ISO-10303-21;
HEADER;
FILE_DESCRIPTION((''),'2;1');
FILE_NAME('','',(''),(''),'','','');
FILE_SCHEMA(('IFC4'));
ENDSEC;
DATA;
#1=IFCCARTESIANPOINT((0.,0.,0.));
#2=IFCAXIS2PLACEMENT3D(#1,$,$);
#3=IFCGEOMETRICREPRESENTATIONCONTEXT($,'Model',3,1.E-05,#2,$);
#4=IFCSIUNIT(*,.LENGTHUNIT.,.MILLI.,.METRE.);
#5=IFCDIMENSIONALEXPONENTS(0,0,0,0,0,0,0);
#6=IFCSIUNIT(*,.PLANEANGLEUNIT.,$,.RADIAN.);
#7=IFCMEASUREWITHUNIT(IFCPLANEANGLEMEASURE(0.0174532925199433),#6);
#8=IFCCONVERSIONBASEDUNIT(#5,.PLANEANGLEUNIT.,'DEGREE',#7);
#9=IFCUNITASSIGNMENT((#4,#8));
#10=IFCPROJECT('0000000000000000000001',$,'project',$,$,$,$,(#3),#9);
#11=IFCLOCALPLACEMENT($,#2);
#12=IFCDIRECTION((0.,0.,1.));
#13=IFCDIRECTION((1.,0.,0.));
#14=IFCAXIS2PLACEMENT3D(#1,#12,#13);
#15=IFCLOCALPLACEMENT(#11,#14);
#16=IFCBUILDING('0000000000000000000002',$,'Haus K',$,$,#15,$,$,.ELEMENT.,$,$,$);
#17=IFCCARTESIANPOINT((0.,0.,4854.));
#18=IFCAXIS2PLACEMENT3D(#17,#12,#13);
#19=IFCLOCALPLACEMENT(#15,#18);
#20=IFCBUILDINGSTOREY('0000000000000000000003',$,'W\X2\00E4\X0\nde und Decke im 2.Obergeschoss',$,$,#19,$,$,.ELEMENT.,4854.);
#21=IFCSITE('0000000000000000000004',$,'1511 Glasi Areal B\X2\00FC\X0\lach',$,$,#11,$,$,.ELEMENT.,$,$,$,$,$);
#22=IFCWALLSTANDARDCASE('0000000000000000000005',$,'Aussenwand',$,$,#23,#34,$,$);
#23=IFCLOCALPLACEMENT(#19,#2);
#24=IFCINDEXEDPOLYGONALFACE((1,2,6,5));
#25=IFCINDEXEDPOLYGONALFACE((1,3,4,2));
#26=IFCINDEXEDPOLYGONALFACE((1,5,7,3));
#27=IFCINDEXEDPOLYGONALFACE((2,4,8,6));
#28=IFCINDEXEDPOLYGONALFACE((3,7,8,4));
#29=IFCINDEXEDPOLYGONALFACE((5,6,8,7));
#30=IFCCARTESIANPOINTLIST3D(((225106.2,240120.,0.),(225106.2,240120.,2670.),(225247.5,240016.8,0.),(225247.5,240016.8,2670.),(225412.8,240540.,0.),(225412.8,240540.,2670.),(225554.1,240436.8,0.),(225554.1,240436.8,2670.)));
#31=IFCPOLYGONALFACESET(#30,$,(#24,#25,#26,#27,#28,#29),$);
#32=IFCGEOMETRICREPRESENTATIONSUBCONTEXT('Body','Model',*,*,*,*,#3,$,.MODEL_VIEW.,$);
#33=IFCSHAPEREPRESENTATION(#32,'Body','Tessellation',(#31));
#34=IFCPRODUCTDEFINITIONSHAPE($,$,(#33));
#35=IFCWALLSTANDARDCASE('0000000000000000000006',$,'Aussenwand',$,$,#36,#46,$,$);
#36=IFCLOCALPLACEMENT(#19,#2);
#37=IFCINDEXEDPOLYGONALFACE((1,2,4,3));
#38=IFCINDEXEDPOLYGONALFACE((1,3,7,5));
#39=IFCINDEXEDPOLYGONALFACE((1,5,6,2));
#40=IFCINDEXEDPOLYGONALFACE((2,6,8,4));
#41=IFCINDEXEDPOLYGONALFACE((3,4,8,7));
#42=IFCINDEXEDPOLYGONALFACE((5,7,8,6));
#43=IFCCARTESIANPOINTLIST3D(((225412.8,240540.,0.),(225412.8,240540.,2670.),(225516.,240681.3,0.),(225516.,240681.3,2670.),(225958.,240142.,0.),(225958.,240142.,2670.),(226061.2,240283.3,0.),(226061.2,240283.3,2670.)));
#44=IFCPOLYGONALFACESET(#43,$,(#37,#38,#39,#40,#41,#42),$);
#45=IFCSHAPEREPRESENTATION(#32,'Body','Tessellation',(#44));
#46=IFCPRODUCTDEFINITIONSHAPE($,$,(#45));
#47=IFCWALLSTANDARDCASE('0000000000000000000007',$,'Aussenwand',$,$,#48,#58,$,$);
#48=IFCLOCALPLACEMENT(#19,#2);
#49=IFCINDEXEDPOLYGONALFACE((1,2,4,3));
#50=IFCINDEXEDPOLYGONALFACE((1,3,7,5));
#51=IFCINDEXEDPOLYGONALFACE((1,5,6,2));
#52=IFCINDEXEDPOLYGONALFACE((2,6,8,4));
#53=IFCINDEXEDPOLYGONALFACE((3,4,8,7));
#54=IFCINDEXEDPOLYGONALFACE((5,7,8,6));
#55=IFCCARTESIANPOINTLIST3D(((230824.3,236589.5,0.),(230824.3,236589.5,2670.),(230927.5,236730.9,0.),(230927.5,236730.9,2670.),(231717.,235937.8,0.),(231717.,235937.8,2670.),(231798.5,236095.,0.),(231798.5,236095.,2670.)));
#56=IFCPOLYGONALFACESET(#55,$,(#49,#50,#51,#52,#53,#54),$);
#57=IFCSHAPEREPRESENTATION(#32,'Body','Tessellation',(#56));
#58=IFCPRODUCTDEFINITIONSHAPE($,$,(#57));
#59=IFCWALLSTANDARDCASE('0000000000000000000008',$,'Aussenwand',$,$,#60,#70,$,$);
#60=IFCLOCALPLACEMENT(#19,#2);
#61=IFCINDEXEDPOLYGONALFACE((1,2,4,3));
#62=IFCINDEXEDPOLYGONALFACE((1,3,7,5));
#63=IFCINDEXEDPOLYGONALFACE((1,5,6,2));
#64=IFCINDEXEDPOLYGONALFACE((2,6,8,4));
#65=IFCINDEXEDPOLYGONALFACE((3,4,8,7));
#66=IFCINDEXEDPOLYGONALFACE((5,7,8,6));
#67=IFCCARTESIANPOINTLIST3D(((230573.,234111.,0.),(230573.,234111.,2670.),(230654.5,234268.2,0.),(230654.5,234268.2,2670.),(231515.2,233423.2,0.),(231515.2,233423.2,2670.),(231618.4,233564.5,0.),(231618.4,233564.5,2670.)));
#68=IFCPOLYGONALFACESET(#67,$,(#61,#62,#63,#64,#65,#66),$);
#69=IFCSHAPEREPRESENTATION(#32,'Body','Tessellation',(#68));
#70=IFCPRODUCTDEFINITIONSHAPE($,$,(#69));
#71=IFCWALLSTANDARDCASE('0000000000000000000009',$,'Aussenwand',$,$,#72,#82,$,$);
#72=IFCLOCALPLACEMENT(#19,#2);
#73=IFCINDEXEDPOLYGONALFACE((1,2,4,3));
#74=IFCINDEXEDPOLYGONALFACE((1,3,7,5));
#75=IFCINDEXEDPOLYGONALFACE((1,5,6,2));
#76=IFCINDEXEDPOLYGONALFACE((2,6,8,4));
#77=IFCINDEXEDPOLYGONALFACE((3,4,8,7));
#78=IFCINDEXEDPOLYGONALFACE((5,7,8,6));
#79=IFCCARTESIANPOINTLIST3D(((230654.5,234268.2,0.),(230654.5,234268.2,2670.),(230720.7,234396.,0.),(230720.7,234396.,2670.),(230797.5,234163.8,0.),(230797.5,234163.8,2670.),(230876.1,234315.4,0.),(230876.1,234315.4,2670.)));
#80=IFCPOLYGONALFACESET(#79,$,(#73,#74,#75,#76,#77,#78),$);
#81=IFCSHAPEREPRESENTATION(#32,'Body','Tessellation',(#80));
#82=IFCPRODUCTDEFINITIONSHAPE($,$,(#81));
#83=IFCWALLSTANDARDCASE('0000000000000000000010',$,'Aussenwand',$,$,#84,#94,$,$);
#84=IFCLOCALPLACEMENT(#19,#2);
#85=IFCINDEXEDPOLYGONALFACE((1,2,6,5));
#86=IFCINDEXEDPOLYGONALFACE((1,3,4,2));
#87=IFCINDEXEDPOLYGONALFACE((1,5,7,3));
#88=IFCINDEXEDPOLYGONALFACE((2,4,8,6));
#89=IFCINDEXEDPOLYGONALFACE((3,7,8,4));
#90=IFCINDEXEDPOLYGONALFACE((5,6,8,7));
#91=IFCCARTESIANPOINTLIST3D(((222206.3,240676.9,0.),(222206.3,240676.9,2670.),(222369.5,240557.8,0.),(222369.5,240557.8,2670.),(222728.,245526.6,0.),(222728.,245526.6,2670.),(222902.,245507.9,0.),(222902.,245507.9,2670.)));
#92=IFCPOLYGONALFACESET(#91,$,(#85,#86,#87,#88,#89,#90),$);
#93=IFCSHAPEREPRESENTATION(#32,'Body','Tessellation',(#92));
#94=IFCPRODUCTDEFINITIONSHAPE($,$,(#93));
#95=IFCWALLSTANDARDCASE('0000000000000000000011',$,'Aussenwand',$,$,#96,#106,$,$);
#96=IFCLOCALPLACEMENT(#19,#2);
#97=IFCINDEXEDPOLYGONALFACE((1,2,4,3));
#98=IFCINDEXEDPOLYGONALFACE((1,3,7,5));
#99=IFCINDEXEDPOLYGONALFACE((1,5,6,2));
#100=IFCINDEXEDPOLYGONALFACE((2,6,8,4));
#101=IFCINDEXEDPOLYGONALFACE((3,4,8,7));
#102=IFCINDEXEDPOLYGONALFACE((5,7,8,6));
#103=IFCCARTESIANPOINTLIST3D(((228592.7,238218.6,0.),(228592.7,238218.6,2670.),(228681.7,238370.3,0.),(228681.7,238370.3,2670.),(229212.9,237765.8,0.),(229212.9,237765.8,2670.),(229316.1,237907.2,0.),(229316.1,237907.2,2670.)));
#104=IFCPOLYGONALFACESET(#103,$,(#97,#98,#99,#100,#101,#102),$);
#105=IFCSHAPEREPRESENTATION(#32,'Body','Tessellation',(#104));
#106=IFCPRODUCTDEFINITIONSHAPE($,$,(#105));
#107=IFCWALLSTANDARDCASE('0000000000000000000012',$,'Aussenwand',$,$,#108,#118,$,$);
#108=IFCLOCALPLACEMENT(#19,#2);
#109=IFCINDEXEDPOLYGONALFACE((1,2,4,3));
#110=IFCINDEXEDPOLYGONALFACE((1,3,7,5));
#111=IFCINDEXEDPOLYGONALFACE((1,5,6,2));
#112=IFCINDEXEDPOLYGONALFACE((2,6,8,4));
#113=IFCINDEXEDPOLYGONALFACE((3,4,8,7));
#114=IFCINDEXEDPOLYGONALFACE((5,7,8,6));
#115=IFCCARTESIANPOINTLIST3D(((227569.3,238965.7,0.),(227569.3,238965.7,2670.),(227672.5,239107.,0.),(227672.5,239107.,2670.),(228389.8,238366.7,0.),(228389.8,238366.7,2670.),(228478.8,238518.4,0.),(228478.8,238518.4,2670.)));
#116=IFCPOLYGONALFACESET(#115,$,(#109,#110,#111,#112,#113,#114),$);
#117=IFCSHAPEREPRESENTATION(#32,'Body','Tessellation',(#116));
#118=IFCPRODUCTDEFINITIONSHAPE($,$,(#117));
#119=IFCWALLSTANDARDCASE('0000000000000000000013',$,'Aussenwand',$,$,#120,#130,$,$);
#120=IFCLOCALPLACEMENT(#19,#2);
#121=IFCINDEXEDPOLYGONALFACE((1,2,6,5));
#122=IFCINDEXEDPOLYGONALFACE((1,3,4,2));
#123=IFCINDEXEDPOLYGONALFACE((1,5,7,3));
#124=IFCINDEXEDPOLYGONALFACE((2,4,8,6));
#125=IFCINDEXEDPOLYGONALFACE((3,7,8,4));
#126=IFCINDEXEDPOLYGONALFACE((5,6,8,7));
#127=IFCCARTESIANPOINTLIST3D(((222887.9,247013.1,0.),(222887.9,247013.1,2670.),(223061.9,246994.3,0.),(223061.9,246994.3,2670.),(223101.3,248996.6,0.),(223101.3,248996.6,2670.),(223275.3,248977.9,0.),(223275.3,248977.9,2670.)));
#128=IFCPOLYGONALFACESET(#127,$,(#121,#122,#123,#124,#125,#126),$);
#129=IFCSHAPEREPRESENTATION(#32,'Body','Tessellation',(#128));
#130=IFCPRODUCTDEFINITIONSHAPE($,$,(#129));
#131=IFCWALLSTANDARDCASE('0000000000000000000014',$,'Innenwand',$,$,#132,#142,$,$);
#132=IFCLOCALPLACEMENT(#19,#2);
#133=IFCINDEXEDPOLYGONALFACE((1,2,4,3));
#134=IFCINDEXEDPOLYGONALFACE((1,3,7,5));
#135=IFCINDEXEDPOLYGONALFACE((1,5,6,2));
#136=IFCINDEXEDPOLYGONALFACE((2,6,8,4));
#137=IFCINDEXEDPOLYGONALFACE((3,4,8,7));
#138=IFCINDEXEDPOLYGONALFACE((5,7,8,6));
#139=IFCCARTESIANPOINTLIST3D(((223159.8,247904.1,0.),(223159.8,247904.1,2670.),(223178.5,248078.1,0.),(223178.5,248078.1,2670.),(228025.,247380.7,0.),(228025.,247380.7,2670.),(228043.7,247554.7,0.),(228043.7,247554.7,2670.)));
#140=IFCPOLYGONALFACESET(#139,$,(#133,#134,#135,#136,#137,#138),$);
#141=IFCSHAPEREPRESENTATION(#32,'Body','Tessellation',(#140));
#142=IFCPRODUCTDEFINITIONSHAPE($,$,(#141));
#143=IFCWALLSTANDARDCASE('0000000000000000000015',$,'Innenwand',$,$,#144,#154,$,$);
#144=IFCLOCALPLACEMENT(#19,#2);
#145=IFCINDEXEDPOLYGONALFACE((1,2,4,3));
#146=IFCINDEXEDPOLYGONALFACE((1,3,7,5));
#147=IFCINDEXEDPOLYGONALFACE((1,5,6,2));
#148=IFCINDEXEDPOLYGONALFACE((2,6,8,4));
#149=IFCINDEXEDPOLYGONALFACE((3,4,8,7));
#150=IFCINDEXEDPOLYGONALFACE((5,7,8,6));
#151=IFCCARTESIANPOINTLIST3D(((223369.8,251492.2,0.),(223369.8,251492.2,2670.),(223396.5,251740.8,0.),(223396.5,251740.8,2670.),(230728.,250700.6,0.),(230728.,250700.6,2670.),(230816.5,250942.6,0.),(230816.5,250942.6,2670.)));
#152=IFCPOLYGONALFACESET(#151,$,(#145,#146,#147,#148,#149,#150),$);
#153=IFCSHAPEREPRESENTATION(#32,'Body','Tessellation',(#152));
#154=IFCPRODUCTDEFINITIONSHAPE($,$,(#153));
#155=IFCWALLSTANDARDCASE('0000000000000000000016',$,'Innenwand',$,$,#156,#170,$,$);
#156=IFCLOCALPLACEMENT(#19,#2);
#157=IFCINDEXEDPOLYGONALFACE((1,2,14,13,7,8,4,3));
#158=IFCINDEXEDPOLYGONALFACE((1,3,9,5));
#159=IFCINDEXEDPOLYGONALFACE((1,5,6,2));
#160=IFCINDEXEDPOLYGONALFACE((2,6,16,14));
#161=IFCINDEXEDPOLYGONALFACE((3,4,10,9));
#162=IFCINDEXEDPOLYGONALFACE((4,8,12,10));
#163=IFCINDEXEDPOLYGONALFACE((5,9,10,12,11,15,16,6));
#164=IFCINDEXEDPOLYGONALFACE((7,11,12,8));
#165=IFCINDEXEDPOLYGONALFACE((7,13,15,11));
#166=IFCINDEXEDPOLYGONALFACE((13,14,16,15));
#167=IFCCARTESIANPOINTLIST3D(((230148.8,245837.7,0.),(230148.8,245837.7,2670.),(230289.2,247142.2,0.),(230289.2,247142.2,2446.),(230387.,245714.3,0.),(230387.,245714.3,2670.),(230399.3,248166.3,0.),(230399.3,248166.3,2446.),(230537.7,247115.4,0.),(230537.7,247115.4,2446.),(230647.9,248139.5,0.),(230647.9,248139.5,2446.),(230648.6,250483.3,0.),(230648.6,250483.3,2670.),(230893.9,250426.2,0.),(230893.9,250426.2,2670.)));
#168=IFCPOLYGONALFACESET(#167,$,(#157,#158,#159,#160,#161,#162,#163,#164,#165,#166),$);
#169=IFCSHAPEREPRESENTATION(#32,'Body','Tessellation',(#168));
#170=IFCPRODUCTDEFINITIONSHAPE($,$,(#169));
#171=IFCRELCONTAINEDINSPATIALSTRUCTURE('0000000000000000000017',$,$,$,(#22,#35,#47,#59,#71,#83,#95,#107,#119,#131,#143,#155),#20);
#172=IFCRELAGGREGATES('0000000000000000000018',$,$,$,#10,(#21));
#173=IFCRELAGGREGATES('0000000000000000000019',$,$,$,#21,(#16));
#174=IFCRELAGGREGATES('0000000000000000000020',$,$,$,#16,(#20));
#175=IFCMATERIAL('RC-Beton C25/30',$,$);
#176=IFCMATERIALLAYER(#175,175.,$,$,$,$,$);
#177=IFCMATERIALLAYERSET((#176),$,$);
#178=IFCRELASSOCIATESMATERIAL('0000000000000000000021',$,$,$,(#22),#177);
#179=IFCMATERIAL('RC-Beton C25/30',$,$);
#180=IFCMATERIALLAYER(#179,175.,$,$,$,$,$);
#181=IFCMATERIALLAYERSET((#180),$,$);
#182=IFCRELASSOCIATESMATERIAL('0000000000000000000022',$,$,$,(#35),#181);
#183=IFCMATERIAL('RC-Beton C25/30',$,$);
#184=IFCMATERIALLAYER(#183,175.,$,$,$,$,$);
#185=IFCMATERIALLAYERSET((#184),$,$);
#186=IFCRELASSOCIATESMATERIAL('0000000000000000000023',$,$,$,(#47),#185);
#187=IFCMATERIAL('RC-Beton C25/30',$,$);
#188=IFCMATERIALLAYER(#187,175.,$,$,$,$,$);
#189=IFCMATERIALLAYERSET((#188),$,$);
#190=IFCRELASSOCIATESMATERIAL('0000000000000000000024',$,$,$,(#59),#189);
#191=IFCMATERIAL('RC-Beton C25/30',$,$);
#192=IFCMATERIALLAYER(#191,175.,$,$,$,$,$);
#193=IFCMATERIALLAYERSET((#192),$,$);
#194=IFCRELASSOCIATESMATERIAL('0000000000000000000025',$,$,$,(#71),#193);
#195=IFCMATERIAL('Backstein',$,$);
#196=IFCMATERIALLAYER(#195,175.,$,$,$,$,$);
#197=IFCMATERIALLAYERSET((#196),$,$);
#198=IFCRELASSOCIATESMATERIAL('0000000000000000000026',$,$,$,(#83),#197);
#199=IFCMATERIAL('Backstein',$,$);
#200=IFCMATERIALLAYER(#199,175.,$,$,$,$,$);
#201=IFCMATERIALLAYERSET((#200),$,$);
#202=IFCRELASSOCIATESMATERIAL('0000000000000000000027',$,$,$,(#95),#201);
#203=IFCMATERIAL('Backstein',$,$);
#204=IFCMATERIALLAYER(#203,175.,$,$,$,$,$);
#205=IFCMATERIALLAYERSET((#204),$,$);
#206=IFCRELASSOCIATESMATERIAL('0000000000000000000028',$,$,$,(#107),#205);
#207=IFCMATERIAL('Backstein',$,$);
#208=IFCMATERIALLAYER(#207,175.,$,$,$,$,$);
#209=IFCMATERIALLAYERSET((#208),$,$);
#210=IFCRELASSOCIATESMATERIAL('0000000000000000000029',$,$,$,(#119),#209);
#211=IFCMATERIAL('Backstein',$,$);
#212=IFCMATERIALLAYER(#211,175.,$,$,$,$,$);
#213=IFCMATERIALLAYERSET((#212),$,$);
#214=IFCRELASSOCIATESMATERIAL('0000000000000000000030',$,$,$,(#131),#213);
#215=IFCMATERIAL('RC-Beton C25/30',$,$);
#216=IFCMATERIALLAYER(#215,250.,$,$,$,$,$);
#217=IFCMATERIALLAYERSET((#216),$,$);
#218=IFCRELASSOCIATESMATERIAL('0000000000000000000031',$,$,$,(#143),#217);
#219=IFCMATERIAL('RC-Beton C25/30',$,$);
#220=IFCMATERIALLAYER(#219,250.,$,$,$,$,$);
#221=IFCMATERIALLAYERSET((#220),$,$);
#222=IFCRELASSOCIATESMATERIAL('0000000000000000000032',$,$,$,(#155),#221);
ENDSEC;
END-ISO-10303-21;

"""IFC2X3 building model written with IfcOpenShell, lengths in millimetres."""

from ifc_helpers import new_model, entity, si_unit, converted_unit, frame, frame_2d, origin, origin_with_axes, place, context, subcontext, project, spatial, polyline, rectangle, outline, extrude, material, layer, layer_set, layer_usage, element, save


model = new_model("IFC2X3")

# Units and contexts
model_context = context("Model", 3, precision=1e-05, world=origin())
body_context = subcontext(model_context, "Body", "Model", "MODEL_VIEW")
ifc_project = project(units=[si_unit("LENGTHUNIT", "METRE", prefix="MILLI"), converted_unit("PLANEANGLEUNIT", "DEGREE", entity("IfcPlaneAngleMeasure", 0.0174532925199433), si_unit("PLANEANGLEUNIT", "RADIAN"), dimensions=[0, 0, 0, 0, 0, 0, 0])], contexts=[model_context])

# Site, building, storey
site_placement = place(None, origin())
site = spatial("IfcSite", under=ifc_project, at=site_placement, Name="1511 Glasi Areal Bülach", CompositionType="ELEMENT")
building_placement = place(site_placement, origin_with_axes())
building = spatial("IfcBuilding", under=site, at=building_placement, Name="Haus K", CompositionType="ELEMENT")
storey_placement = place(building_placement, frame((0.0, 0.0, 4854.0), z_axis=(0.0, 0.0, 1.0), x_axis=(1.0, 0.0, 0.0)))
storey = spatial("IfcBuildingStorey", under=building, at=storey_placement, Name="Wände und Decke im 2.Obergeschoss", CompositionType="ELEMENT", Elevation=4854.0)

# Walls
ifc_material_1 = material(Name="RC-Beton C25/30")
ifc_layer_1 = layer(ifc_material_1, 175.0)
ifc_layer_set_1 = layer_set([ifc_layer_1])
ifc_layer_usage_1 = layer_usage(ifc_layer_set_1, "AXIS2", "POSITIVE", 0.0)
wall_1_placement = place(storey_placement, frame((225247.5, 240016.8, 0.0), z_axis=(0.0, 0.0, 1.0), x_axis=(0.589619, 0.807681, 0.0)))
element("IfcWallStandardCase", 1, at=wall_1_placement, inside=storey, material=ifc_layer_usage_1, Name="Aussenwand", context=body_context, shape_type="SweptSolid", body=[
    extrude(rectangle(XDim=520.0, YDim=175.0, at=frame_2d((260.0, 87.5), x_axis=(1.0, 0.0))), origin_with_axes(), (0.0, 0.0, 1.0), 2670.0),
])
ifc_material_2 = material(Name="RC-Beton C25/30")
ifc_layer_2 = layer(ifc_material_2, 175.0)
ifc_layer_set_2 = layer_set([ifc_layer_2])
ifc_layer_usage_2 = layer_usage(ifc_layer_set_2, "AXIS2", "POSITIVE", 0.0)
wall_2_placement = place(storey_placement, frame((225412.8, 240540.0, 0.0), z_axis=(0.0, 0.0, 1.0), x_axis=(0.807681, -0.589619, 0.0)))
element("IfcWallStandardCase", 2, at=wall_2_placement, inside=storey, material=ifc_layer_usage_2, Name="Aussenwand", context=body_context, shape_type="SweptSolid", body=[
    extrude(rectangle(XDim=675.0, YDim=175.0, at=frame_2d((337.5, 87.5), x_axis=(1.0, 0.0))), origin_with_axes(), (0.0, 0.0, 1.0), 2670.0),
])
ifc_material_3 = material(Name="RC-Beton C25/30")
ifc_layer_3 = layer(ifc_material_3, 175.0)
ifc_layer_set_3 = layer_set([ifc_layer_3])
ifc_layer_usage_3 = layer_usage(ifc_layer_set_3, "AXIS2", "POSITIVE", 0.0)
wall_3_placement = place(storey_placement, frame((230824.3, 236589.5, 0.0), z_axis=(0.0, 0.0, 1.0), x_axis=(0.807681, -0.589619, 0.0)))
element("IfcWallStandardCase", 3, at=wall_3_placement, inside=storey, material=ifc_layer_usage_3, Name="Aussenwand", context=body_context, shape_type="SweptSolid", body=[
    extrude(outline(polyline([(0.0, 0.0), (1105.3, 0.0), (1078.5, 175.0), (0.0, 175.0), (0.0, 0.0)])), origin_with_axes(), (0.0, 0.0, 1.0), 2670.0),
])
ifc_material_4 = material(Name="RC-Beton C25/30")
ifc_layer_4 = layer(ifc_material_4, 175.0)
ifc_layer_set_4 = layer_set([ifc_layer_4])
ifc_layer_usage_4 = layer_usage(ifc_layer_set_4, "AXIS2", "POSITIVE", 0.0)
wall_4_placement = place(storey_placement, frame((230573.0, 234111.0, 0.0), z_axis=(0.0, 0.0, 1.0), x_axis=(0.807681, -0.589619, 0.0)))
element("IfcWallStandardCase", 4, at=wall_4_placement, inside=storey, material=ifc_layer_usage_4, Name="Aussenwand", context=body_context, shape_type="SweptSolid", body=[
    extrude(outline(polyline([(0.0, 0.0), (1166.6, 0.0), (1166.6, 175.0), (-26.9, 175.0), (0.0, 0.0)])), origin_with_axes(), (0.0, 0.0, 1.0), 2670.0),
])
ifc_material_5 = material(Name="RC-Beton C25/30")
ifc_layer_5 = layer(ifc_material_5, 175.0)
ifc_layer_set_5 = layer_set([ifc_layer_5])
ifc_layer_usage_5 = layer_usage(ifc_layer_set_5, "AXIS2", "POSITIVE", 0.0)
wall_5_placement = place(storey_placement, frame((230720.7, 234396.0, 0.0), z_axis=(0.0, 0.0, 1.0), x_axis=(-0.4602, -0.887815, 0.0)))
element("IfcWallStandardCase", 5, at=wall_5_placement, inside=storey, material=ifc_layer_usage_5, Name="Aussenwand", context=body_context, shape_type="SweptSolid", body=[
    extrude(outline(polyline([(0.0, 0.0), (143.9, 0.0), (170.8, 175.0), (0.0, 175.0), (0.0, 0.0)])), origin_with_axes(), (0.0, 0.0, 1.0), 2670.0),
])
ifc_material_6 = material(Name="Backstein")
ifc_layer_6 = layer(ifc_material_6, 175.0)
ifc_layer_set_6 = layer_set([ifc_layer_6])
ifc_layer_usage_6 = layer_usage(ifc_layer_set_6, "AXIS2", "POSITIVE", 0.0)
wall_6_placement = place(storey_placement, frame((222728.0, 245526.6, 0.0), z_axis=(0.0, 0.0, 1.0), x_axis=(-0.106958, -0.994264, 0.0)))
element("IfcWallStandardCase", 6, at=wall_6_placement, inside=storey, material=ifc_layer_usage_6, Name="Aussenwand", context=body_context, shape_type="SweptSolid", body=[
    extrude(outline(polyline([(0.0, 0.0), (4877.7, 0.0), (4978.7, 175.0), (0.0, 175.0), (0.0, 0.0)])), origin_with_axes(), (0.0, 0.0, 1.0), 2670.0),
])
ifc_material_7 = material(Name="Backstein")
ifc_layer_7 = layer(ifc_material_7, 175.0)
ifc_layer_set_7 = layer_set([ifc_layer_7])
ifc_layer_usage_7 = layer_usage(ifc_layer_set_7, "AXIS2", "POSITIVE", 0.0)
wall_7_placement = place(storey_placement, frame((228592.7, 238218.6, 0.0), z_axis=(0.0, 0.0, 1.0), x_axis=(0.807681, -0.589619, 0.0)))
element("IfcWallStandardCase", 7, at=wall_7_placement, inside=storey, material=ifc_layer_usage_7, Name="Aussenwand", context=body_context, shape_type="SweptSolid", body=[
    extrude(outline(polyline([(0.0, 0.0), (767.9, 0.0), (767.9, 175.0), (-17.6, 175.0), (0.0, 0.0)])), origin_with_axes(), (0.0, 0.0, 1.0), 2670.0),
])
ifc_material_8 = material(Name="Backstein")
ifc_layer_8 = layer(ifc_material_8, 175.0)
ifc_layer_set_8 = layer_set([ifc_layer_8])
ifc_layer_usage_8 = layer_usage(ifc_layer_set_8, "AXIS2", "POSITIVE", 0.0)
wall_8_placement = place(storey_placement, frame((227569.3, 238965.7, 0.0), z_axis=(0.0, 0.0, 1.0), x_axis=(0.807681, -0.589619, 0.0)))
element("IfcWallStandardCase", 8, at=wall_8_placement, inside=storey, material=ifc_layer_usage_8, Name="Aussenwand", context=body_context, shape_type="SweptSolid", body=[
    extrude(outline(polyline([(0.0, 0.0), (1015.8, 0.0), (998.3, 175.0), (0.0, 175.0), (0.0, 0.0)])), origin_with_axes(), (0.0, 0.0, 1.0), 2670.0),
])
ifc_material_9 = material(Name="Backstein")
ifc_layer_9 = layer(ifc_material_9, 175.0)
ifc_layer_set_9 = layer_set([ifc_layer_9])
ifc_layer_usage_9 = layer_usage(ifc_layer_set_9, "AXIS2", "POSITIVE", 0.0)
wall_9_placement = place(storey_placement, frame((223101.3, 248996.6, 0.0), z_axis=(0.0, 0.0, 1.0), x_axis=(-0.106958, -0.994264, 0.0)))
element("IfcWallStandardCase", 9, at=wall_9_placement, inside=storey, material=ifc_layer_usage_9, Name="Aussenwand", context=body_context, shape_type="SweptSolid", body=[
    extrude(rectangle(XDim=1995.0, YDim=175.0, at=frame_2d((997.5, 87.5), x_axis=(1.0, 0.0))), origin_with_axes(), (0.0, 0.0, 1.0), 2670.0),
])
ifc_material_10 = material(Name="Backstein")
ifc_layer_10 = layer(ifc_material_10, 175.0)
ifc_layer_set_10 = layer_set([ifc_layer_10])
ifc_layer_usage_10 = layer_usage(ifc_layer_set_10, "AXIS2", "POSITIVE", 0.0)
wall_10_placement = place(storey_placement, frame((223159.8, 247904.1, 0.0), z_axis=(0.0, 0.0, 1.0), x_axis=(0.994264, -0.106958, 0.0)))
element("IfcWallStandardCase", 10, at=wall_10_placement, inside=storey, material=ifc_layer_usage_10, Name="Innenwand", context=body_context, shape_type="SweptSolid", body=[
    extrude(rectangle(XDim=4893.3, YDim=175.0, at=frame_2d((2446.7, 87.5), x_axis=(1.0, 0.0))), origin_with_axes(), (0.0, 0.0, 1.0), 2670.0),
])
ifc_material_11 = material(Name="RC-Beton C25/30")
ifc_layer_11 = layer(ifc_material_11, 250.0)
ifc_layer_set_11 = layer_set([ifc_layer_11])
ifc_layer_usage_11 = layer_usage(ifc_layer_set_11, "AXIS2", "POSITIVE", 0.0)
wall_11_placement = place(storey_placement, frame((230816.5, 250942.6, 0.0), z_axis=(0.0, 0.0, 1.0), x_axis=(-0.994264, 0.106958, 0.0)))
element("IfcWallStandardCase", 11, at=wall_11_placement, inside=storey, material=ifc_layer_usage_11, Name="Innenwand", context=body_context, shape_type="SweptSolid", body=[
    extrude(outline(polyline([(0.0, 0.0), (7462.8, 0.0), (7462.8, 250.0), (62.1, 250.0), (0.0, 0.0)])), origin_with_axes(), (0.0, 0.0, 1.0), 2670.0),
])

# Wall, opening
ifc_material_12 = material(Name="RC-Beton C25/30")
ifc_layer_12 = layer(ifc_material_12, 250.0)
ifc_layer_set_12 = layer_set([ifc_layer_12])
ifc_layer_usage_12 = layer_usage(ifc_layer_set_12, "AXIS2", "POSITIVE", 0.0)
wall_12_placement = place(storey_placement, frame((230387.0, 245714.3, 0.0), z_axis=(0.0, 0.0, 1.0), x_axis=(0.106958, 0.994264, 0.0)))
wall_12 = element("IfcWallStandardCase", 12, at=wall_12_placement, inside=storey, material=ifc_layer_usage_12, Name="Innenwand", context=body_context, shape_type="SweptSolid", body=[
    extrude(outline(polyline([(0.0, 0.0), (4739.1, 0.0), (4769.7, 250.0), (97.3, 250.0), (0.0, 0.0)])), origin_with_axes(), (0.0, 0.0, 1.0), 2670.0),
])
opening_1_placement = place(wall_12_placement, frame((1409.2, 0.0, 0.0), z_axis=(0.0, 1.0, 0.0), x_axis=(0.0, 0.0, 1.0)))
element("IfcOpeningElement", 13, at=opening_1_placement, cuts=wall_12, ObjectType="Opening", context=body_context, shape_type="SweptSolid", body=[
    extrude(rectangle(XDim=2446.0, YDim=1030.0, at=frame_2d((1223.0, 515.0), x_axis=(1.0, 0.0))), origin_with_axes(), (0.0, 0.0, 1.0), 250.0),
])

save(model, "model.ifc")
